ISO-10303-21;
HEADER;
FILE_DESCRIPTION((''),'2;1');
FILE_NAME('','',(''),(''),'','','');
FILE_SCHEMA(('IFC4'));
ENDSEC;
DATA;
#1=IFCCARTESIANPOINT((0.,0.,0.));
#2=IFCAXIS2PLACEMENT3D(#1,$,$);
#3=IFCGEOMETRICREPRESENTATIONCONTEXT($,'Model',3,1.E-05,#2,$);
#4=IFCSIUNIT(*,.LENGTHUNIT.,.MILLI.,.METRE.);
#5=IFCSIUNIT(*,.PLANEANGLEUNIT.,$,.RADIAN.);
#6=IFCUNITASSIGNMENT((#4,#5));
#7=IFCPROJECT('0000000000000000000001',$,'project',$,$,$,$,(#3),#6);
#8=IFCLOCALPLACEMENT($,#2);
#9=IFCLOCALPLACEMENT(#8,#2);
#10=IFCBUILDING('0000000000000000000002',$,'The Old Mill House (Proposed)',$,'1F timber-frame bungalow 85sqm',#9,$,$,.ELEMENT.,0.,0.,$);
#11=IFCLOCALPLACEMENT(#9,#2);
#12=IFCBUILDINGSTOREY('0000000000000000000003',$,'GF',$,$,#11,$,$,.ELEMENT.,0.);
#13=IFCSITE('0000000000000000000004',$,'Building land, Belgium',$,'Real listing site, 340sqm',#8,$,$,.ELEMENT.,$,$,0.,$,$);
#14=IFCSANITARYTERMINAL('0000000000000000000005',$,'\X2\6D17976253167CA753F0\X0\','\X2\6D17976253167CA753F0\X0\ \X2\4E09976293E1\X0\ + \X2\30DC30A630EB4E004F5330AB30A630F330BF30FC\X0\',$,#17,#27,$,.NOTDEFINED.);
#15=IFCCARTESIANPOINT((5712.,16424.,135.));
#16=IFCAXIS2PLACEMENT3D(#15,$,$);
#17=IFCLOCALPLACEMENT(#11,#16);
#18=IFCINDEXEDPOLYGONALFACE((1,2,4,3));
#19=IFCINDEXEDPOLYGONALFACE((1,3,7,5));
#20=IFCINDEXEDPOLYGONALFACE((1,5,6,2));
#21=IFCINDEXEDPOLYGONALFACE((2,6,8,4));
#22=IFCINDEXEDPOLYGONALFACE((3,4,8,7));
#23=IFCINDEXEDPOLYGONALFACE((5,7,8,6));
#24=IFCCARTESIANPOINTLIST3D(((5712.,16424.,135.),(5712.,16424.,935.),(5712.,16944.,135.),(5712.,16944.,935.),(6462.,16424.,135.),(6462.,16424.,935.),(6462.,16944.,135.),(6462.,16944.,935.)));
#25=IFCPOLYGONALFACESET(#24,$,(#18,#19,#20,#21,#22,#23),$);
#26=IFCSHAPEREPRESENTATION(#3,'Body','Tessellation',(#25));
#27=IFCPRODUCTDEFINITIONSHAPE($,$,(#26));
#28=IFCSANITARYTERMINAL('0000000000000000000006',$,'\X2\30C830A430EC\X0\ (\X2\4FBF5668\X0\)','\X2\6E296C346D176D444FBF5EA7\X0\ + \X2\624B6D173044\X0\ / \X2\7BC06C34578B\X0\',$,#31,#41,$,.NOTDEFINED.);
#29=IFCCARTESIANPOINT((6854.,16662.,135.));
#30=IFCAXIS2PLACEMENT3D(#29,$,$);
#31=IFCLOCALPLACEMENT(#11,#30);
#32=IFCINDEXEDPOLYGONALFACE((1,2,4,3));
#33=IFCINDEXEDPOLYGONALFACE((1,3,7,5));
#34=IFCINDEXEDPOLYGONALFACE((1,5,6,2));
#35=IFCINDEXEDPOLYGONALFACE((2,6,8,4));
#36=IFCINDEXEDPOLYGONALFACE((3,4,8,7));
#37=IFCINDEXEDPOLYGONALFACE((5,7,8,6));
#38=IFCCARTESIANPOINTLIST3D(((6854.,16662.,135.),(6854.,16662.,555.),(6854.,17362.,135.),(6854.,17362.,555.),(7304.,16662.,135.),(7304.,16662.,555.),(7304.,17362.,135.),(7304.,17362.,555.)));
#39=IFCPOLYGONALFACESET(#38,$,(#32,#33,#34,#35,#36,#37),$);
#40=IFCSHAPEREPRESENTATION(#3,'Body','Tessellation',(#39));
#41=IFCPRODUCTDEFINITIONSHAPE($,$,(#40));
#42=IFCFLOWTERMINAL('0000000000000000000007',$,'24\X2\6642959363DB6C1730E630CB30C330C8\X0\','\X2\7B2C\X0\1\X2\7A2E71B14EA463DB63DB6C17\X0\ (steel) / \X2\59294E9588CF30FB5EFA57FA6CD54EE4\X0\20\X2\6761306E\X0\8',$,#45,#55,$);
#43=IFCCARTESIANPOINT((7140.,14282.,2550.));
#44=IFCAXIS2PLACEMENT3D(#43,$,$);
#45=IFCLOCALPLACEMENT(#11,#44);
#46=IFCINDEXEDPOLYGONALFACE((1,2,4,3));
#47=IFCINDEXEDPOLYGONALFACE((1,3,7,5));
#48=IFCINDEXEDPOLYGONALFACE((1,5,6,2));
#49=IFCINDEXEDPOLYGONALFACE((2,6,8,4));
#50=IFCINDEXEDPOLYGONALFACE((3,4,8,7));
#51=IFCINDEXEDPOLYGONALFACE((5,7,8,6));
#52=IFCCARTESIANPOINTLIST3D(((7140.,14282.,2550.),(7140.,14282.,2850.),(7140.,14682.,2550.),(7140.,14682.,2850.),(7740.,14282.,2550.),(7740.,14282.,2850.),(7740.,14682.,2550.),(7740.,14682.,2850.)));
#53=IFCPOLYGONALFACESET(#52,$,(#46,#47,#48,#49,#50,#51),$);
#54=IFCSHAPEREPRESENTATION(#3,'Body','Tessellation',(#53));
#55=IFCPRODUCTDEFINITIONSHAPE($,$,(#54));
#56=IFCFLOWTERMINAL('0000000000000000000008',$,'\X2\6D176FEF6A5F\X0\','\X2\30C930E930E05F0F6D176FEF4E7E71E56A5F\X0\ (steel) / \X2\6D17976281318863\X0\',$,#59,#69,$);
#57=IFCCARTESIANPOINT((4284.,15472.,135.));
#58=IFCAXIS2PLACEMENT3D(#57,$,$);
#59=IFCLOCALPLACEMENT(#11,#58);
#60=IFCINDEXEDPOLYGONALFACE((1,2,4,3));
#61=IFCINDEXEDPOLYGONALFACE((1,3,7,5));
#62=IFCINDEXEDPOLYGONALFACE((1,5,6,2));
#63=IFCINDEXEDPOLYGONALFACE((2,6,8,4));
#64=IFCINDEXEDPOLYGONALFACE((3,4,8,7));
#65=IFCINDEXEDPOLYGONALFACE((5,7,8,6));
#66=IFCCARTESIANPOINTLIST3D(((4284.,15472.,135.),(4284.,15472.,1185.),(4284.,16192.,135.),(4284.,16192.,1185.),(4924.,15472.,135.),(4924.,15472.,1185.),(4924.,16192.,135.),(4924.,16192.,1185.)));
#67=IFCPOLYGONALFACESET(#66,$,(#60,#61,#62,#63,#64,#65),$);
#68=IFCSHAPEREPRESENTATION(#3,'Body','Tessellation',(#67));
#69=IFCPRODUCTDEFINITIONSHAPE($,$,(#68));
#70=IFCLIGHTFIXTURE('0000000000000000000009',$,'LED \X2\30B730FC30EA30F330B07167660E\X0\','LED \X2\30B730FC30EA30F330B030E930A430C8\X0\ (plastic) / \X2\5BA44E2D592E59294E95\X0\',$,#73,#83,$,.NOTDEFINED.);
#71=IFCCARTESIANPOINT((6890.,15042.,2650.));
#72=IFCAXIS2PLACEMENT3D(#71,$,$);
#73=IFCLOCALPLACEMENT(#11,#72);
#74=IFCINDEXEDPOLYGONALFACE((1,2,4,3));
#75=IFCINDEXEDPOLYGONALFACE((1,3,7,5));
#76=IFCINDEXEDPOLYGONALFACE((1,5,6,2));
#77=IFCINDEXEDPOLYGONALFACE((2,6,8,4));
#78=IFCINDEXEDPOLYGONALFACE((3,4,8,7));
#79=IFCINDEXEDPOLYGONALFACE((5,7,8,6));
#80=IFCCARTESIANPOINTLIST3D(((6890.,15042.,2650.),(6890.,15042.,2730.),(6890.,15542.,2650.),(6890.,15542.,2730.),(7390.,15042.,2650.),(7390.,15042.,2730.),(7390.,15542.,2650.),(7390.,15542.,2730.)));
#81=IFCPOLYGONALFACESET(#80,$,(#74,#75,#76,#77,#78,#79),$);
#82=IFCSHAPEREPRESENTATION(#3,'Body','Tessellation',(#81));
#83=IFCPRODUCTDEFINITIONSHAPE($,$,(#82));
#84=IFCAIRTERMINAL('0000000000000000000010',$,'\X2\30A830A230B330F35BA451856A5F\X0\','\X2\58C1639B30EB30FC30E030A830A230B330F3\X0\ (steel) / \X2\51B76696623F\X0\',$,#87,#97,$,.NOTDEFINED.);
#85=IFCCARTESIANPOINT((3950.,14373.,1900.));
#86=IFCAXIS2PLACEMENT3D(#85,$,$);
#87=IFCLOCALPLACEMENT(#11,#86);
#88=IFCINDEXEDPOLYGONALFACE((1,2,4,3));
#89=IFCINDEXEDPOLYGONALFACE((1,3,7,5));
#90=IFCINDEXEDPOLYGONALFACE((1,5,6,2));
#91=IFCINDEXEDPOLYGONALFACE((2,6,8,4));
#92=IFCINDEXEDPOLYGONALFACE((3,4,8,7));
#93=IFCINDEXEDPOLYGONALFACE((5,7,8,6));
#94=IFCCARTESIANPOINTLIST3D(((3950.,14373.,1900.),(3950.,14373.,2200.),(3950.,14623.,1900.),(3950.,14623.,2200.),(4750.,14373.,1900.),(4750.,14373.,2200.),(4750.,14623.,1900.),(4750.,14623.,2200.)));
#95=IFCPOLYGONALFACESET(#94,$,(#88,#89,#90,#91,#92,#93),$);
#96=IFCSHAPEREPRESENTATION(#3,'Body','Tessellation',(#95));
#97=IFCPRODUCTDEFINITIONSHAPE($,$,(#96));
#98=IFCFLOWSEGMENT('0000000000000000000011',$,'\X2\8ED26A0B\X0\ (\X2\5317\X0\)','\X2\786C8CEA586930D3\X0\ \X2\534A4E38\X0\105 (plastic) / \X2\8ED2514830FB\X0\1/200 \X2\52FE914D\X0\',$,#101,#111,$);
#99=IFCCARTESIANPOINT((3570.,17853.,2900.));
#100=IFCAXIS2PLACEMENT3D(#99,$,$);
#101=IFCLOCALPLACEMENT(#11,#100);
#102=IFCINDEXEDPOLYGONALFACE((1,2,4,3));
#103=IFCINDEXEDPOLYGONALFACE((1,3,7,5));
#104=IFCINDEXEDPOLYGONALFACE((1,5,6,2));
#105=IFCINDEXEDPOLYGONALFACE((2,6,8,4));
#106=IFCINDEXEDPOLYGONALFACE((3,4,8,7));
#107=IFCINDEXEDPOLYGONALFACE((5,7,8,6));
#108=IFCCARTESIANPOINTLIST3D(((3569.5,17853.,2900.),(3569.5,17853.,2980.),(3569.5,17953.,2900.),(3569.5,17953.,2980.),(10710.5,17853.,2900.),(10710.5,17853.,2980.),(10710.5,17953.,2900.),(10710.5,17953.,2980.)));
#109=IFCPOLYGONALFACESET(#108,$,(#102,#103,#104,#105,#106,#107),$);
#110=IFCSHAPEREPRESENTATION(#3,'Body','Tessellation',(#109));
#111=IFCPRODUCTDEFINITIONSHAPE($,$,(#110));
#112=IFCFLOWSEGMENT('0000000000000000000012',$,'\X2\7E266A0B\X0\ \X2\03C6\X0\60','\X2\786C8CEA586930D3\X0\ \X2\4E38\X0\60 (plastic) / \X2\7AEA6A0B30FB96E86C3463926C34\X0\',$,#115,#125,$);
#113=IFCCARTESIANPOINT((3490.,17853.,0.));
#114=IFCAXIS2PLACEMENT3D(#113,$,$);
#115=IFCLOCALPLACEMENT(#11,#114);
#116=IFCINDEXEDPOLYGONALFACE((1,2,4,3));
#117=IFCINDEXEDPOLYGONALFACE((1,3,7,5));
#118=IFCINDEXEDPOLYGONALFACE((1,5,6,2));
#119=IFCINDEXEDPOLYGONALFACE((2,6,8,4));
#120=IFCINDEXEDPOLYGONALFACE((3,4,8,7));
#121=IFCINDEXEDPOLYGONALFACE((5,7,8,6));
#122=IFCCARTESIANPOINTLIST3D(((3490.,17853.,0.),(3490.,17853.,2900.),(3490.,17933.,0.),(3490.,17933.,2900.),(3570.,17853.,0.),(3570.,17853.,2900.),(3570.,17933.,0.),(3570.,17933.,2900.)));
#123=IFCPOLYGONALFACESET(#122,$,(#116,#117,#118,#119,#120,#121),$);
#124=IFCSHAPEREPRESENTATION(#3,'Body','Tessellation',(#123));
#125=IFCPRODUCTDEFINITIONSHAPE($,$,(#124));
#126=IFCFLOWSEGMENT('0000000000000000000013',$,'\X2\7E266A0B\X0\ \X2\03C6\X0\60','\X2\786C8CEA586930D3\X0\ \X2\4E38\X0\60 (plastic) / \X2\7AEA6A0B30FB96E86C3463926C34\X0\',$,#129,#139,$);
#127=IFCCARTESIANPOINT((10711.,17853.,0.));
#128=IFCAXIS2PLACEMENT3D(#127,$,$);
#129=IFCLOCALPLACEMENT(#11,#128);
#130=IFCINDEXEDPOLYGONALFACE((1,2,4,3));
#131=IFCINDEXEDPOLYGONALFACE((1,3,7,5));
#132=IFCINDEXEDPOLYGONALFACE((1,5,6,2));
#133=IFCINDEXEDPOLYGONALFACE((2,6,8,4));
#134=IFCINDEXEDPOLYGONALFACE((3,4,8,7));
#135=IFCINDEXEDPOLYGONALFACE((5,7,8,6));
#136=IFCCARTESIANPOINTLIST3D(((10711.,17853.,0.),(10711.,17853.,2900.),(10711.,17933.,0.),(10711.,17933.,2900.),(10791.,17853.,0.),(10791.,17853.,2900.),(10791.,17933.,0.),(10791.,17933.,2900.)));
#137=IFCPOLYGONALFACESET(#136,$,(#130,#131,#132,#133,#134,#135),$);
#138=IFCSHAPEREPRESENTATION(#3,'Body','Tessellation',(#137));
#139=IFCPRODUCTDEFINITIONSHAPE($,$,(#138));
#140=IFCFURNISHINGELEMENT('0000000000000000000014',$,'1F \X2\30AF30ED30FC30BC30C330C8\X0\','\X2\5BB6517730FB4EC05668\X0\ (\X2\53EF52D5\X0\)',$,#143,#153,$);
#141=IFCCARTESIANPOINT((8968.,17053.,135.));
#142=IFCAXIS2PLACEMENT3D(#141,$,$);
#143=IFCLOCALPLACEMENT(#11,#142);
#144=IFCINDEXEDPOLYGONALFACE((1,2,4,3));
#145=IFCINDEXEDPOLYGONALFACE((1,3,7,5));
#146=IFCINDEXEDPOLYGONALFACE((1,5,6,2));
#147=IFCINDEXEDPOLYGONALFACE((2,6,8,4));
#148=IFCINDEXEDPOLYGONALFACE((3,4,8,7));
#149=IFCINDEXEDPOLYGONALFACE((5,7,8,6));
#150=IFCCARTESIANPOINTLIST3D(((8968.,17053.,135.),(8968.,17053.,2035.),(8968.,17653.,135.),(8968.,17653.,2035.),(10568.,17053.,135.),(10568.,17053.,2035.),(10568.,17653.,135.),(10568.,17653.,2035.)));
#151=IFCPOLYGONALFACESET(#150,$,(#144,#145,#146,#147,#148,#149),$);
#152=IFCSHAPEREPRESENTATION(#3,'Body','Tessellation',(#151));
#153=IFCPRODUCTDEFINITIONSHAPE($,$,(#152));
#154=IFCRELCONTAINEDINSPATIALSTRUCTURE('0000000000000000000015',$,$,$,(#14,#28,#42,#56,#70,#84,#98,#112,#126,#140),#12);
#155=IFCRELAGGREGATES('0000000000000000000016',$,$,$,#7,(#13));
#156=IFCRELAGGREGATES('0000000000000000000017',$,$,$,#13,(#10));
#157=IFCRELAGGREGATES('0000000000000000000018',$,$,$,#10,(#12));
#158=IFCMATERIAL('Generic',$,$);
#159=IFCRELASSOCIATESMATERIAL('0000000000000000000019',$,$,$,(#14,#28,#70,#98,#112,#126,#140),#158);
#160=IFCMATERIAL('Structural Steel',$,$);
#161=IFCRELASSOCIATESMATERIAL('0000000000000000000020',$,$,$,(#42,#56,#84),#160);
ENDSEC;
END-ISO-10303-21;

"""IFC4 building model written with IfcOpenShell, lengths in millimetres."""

from ifc_helpers import new_model, si_unit, frame, frame_2d, origin, place, context, project, spatial, rectangle, extrude, material, element, save


model = new_model("IFC4")

# Units and contexts
model_context = context("Model", 3, precision=1e-05, world=origin())
ifc_project = project(units=[si_unit("LENGTHUNIT", "METRE", prefix="MILLI"), si_unit("PLANEANGLEUNIT", "RADIAN")], contexts=[model_context])

# Site, building, storey
site_placement = place(None, origin())
site = spatial("IfcSite", under=ifc_project, at=site_placement, Name="Building land, Belgium", ObjectType="Real listing site, 340sqm", CompositionType="ELEMENT", RefElevation=0.0)
building_placement = place(site_placement, origin())
building = spatial("IfcBuilding", under=site, at=building_placement, Name="The Old Mill House (Proposed)", ObjectType="1F timber-frame bungalow 85sqm", CompositionType="ELEMENT", ElevationOfRefHeight=0.0, ElevationOfTerrain=0.0)
storey_placement = place(building_placement, origin())
storey = spatial("IfcBuildingStorey", under=building, at=storey_placement, Name="GF", CompositionType="ELEMENT", Elevation=0.0)

# Shared definitions
ifc_material_1 = material(Name="Generic")

# Sanitary terminals
sanitary_terminal_1_placement = place(storey_placement, frame((5712.0, 16424.0, 135.0)))
element("IfcSanitaryTerminal", 1, at=sanitary_terminal_1_placement, inside=storey, material=ifc_material_1, Name="洗面化粧台", Description="洗面化粧台 三面鏡 + ボウル一体カウンター", PredefinedType="NOTDEFINED", context=model_context, shape_type="SweptSolid", body=[
    extrude(rectangle(XDim=750.0, YDim=520.0, at=frame_2d((375.0, 260.0))), frame((5712.0, 16424.0, 135.0)), (0.0, 0.0, 1.0), 800.0),
])
sanitary_terminal_2_placement = place(storey_placement, frame((6854.0, 16662.0, 135.0)))
element("IfcSanitaryTerminal", 2, at=sanitary_terminal_2_placement, inside=storey, material=ifc_material_1, Name="トイレ (便器)", Description="温水洗浄便座 + 手洗い / 節水型", PredefinedType="NOTDEFINED", context=model_context, shape_type="SweptSolid", body=[
    extrude(rectangle(XDim=450.0, YDim=700.0, at=frame_2d((225.0, 350.0))), frame((6854.0, 16662.0, 135.0)), (0.0, 0.0, 1.0), 420.0),
])

# Flow terminals
ifc_material_2 = material(Name="Structural Steel")
flow_terminal_1_placement = place(storey_placement, frame((7140.0, 14282.0, 2550.0)))
element("IfcFlowTerminal", 3, at=flow_terminal_1_placement, inside=storey, material=ifc_material_2, Name="24時間換気ユニット", Description="第1種熱交換換気 (steel) / 天井裏・建基法令20条の8", context=model_context, shape_type="SweptSolid", body=[
    extrude(rectangle(XDim=600.0, YDim=400.0, at=frame_2d((300.0, 200.0))), frame((7140.0, 14282.0, 2550.0)), (0.0, 0.0, 1.0), 300.0),
])
flow_terminal_2_placement = place(storey_placement, frame((4284.0, 15472.0, 135.0)))
element("IfcFlowTerminal", 4, at=flow_terminal_2_placement, inside=storey, material=ifc_material_2, Name="洗濯機", Description="ドラム式洗濯乾燥機 (steel) / 洗面脱衣", context=model_context, shape_type="SweptSolid", body=[
    extrude(rectangle(XDim=640.0, YDim=720.0, at=frame_2d((320.0, 360.0))), frame((4284.0, 15472.0, 135.0)), (0.0, 0.0, 1.0), 1050.0),
])

# Light fixture
light_fixture_placement = place(storey_placement, frame((6890.0, 15042.0, 2650.0)))
element("IfcLightFixture", 5, at=light_fixture_placement, inside=storey, material=ifc_material_1, Name="LED シーリング照明", Description="LED シーリングライト (plastic) / 室中央天井", PredefinedType="NOTDEFINED", context=model_context, shape_type="SweptSolid", body=[
    extrude(rectangle(XDim=500.0, YDim=500.0, at=frame_2d((250.0, 250.0))), frame((6890.0, 15042.0, 2650.0)), (0.0, 0.0, 1.0), 80.0),
])

# Air terminal
air_terminal_placement = place(storey_placement, frame((3950.0, 14373.0, 1900.0)))
element("IfcAirTerminal", 6, at=air_terminal_placement, inside=storey, material=ifc_material_2, Name="エアコン室内機", Description="壁掛ルームエアコン (steel) / 冷暖房", PredefinedType="NOTDEFINED", context=model_context, shape_type="SweptSolid", body=[
    extrude(rectangle(XDim=800.0, YDim=250.0, at=frame_2d((400.0, 125.0))), frame((3950.0, 14373.0, 1900.0)), (0.0, 0.0, 1.0), 300.0),
])

# Flow segments
flow_segment_1_placement = place(storey_placement, frame((3570.0, 17853.0, 2900.0)))
element("IfcFlowSegment", 7, at=flow_segment_1_placement, inside=storey, material=ifc_material_1, Name="軒樋 (北)", Description="硬質塩ビ 半丸105 (plastic) / 軒先・1/200 勾配", context=model_context, shape_type="SweptSolid", body=[
    extrude(rectangle(XDim=7141.0, YDim=100.0, at=frame_2d((3570.0, 50.0))), frame((3570.0, 17853.0, 2900.0)), (0.0, 0.0, 1.0), 80.0),
])
flow_segment_2_placement = place(storey_placement, frame((3490.0, 17853.0, 0.0)))
element("IfcFlowSegment", 8, at=flow_segment_2_placement, inside=storey, material=ifc_material_1, Name="縦樋 φ60", Description="硬質塩ビ 丸60 (plastic) / 竪樋・雨水排水", context=model_context, shape_type="SweptSolid", body=[
    extrude(rectangle(XDim=80.0, YDim=80.0, at=frame_2d((40.0, 40.0))), frame((3490.0, 17853.0, 0.0)), (0.0, 0.0, 1.0), 2900.0),
])
flow_segment_3_placement = place(storey_placement, frame((10711.0, 17853.0, 0.0)))
element("IfcFlowSegment", 9, at=flow_segment_3_placement, inside=storey, material=ifc_material_1, Name="縦樋 φ60", Description="硬質塩ビ 丸60 (plastic) / 竪樋・雨水排水", context=model_context, shape_type="SweptSolid", body=[
    extrude(rectangle(XDim=80.0, YDim=80.0, at=frame_2d((40.0, 40.0))), frame((10711.0, 17853.0, 0.0)), (0.0, 0.0, 1.0), 2900.0),
])

# Furnishing element
furnishing_placement = place(storey_placement, frame((8968.0, 17053.0, 135.0)))
element("IfcFurnishingElement", 10, at=furnishing_placement, inside=storey, material=ifc_material_1, Name="1F クローゼット", Description="家具・什器 (可動)", context=model_context, shape_type="SweptSolid", body=[
    extrude(rectangle(XDim=1600.0, YDim=600.0, at=frame_2d((800.0, 300.0))), frame((8968.0, 17053.0, 135.0)), (0.0, 0.0, 1.0), 1900.0),
])

save(model, "model.ifc")
